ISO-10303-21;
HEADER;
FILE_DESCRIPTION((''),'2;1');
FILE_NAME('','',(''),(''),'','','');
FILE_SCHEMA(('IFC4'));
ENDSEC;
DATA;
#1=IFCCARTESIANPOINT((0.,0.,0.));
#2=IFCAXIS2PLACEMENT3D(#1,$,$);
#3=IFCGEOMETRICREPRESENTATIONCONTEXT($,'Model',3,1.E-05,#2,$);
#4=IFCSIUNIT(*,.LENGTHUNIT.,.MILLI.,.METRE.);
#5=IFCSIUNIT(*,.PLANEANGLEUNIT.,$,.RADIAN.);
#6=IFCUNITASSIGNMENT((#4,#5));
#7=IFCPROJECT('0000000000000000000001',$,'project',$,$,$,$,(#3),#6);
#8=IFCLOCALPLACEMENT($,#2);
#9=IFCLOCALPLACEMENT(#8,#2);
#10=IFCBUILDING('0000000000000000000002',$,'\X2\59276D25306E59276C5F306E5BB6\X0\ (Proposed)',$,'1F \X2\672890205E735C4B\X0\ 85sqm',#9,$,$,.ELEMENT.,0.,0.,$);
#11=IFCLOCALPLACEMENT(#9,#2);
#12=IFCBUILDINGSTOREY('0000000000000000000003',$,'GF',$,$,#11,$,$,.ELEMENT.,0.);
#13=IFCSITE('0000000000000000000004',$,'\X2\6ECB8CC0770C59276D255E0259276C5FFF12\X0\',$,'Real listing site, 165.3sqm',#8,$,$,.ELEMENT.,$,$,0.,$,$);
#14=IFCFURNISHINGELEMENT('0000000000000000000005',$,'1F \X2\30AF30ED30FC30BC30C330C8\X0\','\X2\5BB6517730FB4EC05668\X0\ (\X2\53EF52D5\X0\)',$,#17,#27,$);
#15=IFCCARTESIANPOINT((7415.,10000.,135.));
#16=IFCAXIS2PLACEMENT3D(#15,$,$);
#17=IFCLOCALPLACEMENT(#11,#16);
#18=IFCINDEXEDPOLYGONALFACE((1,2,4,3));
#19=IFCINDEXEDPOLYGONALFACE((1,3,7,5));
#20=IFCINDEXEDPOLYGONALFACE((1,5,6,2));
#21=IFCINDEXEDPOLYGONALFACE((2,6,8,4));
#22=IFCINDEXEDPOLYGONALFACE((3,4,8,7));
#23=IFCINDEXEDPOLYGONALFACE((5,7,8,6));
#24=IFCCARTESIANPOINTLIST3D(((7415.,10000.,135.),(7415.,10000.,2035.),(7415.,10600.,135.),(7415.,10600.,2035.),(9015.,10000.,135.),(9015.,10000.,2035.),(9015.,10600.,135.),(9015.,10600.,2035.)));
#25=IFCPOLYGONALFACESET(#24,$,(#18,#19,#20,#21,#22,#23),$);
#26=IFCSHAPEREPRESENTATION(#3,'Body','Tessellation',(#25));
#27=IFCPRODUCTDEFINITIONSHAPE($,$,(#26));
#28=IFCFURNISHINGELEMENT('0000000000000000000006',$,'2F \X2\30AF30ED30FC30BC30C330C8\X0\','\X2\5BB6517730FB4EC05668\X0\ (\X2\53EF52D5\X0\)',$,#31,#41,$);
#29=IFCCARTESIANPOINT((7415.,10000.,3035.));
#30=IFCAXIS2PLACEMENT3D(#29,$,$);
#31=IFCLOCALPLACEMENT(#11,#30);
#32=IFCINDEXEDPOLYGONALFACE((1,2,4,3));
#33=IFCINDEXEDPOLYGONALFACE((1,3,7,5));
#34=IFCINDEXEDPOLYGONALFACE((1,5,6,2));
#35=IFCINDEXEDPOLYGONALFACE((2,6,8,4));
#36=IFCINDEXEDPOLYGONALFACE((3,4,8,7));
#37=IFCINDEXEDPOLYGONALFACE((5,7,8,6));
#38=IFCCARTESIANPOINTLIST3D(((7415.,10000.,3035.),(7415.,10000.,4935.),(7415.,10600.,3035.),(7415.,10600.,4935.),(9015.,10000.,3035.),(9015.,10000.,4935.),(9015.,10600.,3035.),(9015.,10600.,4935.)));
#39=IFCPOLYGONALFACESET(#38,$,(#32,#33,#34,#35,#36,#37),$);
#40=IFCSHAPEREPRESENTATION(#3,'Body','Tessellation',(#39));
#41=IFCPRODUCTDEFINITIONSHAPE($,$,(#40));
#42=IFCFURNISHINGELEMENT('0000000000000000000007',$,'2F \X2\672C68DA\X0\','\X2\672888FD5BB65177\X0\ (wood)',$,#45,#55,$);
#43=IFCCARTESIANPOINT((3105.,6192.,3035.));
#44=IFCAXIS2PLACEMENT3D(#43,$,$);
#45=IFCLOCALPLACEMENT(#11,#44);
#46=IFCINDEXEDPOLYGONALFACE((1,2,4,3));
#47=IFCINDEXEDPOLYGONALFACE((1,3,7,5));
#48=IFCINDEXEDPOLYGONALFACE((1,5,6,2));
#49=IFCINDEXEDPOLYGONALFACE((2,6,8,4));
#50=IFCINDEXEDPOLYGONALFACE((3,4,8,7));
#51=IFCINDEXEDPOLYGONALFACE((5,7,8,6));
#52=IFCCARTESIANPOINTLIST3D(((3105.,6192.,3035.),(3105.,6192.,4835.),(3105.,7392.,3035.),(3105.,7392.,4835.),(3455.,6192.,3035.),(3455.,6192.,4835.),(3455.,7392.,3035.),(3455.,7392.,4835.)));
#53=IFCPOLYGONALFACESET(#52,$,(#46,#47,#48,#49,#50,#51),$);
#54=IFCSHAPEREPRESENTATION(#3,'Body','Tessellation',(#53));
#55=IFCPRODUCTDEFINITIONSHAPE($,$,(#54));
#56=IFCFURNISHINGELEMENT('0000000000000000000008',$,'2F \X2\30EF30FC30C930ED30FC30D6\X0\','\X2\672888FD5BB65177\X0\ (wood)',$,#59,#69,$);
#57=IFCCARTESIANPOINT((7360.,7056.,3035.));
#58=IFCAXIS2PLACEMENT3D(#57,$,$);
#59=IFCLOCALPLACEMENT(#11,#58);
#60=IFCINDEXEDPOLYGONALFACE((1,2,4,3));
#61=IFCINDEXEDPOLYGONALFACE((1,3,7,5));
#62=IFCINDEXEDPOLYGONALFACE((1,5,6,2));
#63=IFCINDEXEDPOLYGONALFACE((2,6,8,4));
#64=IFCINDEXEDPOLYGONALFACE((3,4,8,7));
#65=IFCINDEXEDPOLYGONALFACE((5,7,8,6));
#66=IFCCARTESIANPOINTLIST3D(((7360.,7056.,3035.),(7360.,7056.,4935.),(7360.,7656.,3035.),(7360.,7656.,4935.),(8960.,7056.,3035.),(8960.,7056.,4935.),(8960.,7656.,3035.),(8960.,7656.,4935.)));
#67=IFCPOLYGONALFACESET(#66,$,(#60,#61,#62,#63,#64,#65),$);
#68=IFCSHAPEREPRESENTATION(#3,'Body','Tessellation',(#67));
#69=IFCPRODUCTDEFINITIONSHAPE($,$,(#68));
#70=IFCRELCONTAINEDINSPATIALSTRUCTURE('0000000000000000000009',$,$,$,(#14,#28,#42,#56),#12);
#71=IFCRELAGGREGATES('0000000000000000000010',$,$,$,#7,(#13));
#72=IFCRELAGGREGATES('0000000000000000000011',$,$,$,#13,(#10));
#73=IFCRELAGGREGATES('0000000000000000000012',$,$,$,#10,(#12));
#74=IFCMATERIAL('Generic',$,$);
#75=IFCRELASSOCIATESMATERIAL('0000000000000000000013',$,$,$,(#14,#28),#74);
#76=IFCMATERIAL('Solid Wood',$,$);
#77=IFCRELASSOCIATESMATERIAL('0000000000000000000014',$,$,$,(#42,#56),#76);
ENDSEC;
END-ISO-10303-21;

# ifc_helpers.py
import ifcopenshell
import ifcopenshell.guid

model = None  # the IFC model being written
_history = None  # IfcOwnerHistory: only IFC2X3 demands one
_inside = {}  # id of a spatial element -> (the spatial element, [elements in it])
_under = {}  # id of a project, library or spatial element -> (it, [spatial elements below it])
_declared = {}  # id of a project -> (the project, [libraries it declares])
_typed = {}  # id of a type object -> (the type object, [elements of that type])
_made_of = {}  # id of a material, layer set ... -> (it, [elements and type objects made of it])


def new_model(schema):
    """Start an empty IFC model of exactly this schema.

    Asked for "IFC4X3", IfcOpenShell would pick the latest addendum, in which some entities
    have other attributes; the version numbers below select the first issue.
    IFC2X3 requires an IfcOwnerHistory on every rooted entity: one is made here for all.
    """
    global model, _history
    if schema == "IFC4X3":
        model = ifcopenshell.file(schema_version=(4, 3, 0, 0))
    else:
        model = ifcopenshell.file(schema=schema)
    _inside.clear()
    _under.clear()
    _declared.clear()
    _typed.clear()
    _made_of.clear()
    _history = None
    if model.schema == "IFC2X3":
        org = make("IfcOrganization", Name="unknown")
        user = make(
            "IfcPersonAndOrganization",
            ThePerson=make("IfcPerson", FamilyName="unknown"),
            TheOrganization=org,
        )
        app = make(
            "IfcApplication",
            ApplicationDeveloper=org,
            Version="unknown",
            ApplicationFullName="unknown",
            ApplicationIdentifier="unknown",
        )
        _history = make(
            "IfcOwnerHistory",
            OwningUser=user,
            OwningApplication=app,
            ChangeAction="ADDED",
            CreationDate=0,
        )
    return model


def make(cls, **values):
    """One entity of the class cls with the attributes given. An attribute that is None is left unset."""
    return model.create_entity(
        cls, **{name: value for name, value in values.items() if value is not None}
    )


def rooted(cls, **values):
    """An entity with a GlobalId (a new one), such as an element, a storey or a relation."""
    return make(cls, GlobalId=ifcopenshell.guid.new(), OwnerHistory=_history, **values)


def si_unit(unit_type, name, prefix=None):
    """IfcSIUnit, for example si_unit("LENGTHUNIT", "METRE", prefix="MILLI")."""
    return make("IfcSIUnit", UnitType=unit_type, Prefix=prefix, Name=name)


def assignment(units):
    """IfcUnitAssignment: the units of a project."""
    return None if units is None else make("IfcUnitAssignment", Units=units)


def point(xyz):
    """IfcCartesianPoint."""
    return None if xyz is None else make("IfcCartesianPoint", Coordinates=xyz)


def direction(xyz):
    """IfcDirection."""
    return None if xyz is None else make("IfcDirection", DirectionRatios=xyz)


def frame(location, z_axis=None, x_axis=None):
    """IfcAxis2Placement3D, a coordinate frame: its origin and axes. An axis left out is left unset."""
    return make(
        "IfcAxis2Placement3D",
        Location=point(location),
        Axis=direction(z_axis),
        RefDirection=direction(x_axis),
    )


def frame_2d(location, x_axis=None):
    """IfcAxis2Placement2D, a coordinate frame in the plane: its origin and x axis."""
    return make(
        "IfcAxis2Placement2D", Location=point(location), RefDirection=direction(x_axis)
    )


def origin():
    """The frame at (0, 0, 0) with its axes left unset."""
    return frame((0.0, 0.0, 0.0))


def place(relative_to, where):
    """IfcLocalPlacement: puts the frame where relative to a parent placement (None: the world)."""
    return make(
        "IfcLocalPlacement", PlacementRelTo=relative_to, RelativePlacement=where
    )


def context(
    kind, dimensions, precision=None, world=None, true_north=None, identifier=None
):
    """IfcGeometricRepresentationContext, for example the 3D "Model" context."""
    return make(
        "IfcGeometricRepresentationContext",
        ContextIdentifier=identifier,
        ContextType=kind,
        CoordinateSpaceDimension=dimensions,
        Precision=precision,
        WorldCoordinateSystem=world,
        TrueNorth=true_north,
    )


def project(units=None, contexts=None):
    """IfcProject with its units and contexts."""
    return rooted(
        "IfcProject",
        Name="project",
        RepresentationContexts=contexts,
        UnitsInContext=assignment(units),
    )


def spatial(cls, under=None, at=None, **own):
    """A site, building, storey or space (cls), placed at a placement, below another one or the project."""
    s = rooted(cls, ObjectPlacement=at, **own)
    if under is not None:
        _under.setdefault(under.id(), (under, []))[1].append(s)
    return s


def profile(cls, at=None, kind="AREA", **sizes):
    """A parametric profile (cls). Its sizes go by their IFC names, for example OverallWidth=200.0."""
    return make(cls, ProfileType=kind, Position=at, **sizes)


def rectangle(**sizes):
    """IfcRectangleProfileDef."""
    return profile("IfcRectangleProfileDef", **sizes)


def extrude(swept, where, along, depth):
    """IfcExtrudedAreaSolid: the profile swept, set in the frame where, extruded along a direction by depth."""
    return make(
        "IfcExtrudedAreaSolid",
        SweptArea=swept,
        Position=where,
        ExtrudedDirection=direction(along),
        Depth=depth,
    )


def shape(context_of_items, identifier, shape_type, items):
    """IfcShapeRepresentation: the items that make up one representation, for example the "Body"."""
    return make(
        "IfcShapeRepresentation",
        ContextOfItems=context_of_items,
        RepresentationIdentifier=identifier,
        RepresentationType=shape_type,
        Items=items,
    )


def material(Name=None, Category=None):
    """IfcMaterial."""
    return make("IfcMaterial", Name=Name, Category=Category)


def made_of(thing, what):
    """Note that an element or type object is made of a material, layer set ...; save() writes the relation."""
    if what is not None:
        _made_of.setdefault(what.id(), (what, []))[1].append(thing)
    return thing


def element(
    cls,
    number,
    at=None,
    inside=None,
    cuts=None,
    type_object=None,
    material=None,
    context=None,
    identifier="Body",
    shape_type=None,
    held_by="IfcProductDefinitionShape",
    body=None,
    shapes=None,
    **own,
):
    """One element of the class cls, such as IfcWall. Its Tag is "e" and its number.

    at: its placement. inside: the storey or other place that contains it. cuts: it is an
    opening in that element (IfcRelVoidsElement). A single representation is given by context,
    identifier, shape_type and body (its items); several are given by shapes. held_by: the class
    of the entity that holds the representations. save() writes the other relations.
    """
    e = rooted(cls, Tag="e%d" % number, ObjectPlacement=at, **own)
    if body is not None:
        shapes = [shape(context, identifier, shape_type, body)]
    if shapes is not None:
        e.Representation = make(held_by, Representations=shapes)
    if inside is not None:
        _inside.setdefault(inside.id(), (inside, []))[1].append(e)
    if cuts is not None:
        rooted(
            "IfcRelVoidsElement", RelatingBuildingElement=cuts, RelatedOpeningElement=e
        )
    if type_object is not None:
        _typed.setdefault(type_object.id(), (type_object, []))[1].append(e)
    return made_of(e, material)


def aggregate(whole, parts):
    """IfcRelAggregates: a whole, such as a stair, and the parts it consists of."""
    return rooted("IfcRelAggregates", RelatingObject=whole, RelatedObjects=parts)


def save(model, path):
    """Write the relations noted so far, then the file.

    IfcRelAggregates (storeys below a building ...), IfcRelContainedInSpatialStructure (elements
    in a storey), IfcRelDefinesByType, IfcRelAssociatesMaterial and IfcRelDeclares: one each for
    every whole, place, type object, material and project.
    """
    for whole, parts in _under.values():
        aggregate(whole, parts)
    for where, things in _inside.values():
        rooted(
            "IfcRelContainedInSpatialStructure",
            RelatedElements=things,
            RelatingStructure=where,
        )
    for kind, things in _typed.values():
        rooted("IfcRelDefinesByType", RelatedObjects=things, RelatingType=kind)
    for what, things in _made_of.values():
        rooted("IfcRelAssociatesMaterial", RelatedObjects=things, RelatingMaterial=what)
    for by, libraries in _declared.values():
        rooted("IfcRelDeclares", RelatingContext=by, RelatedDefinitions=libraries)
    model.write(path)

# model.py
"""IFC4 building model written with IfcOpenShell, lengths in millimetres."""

from ifc_helpers import new_model, si_unit, frame, frame_2d, origin, place, context, project, spatial, rectangle, extrude, material, element, save


model = new_model("IFC4")

# Units and contexts
model_context = context("Model", 3, precision=1e-05, world=origin())
ifc_project = project(units=[si_unit("LENGTHUNIT", "METRE", prefix="MILLI"), si_unit("PLANEANGLEUNIT", "RADIAN")], contexts=[model_context])

# Site, building, storey
site_placement = place(None, origin())
site = spatial("IfcSite", under=ifc_project, at=site_placement, Name="滋賀県大津市大江２", ObjectType="Real listing site, 165.3sqm", CompositionType="ELEMENT", RefElevation=0.0)
building_placement = place(site_placement, origin())
building = spatial("IfcBuilding", under=site, at=building_placement, Name="大津の大江の家 (Proposed)", ObjectType="1F 木造平屋 85sqm", CompositionType="ELEMENT", ElevationOfRefHeight=0.0, ElevationOfTerrain=0.0)
storey_placement = place(building_placement, origin())
storey = spatial("IfcBuildingStorey", under=building, at=storey_placement, Name="GF", CompositionType="ELEMENT", Elevation=0.0)

# Shared definitions
ifc_material_1 = material(Name="Solid Wood")

# Shared definitions
ifc_material_2 = material(Name="Generic")

# Furnishing elements
furnishing_1_placement = place(storey_placement, frame((7415.0, 10000.0, 135.0)))
element("IfcFurnishingElement", 1, at=furnishing_1_placement, inside=storey, material=ifc_material_2, Name="1F クローゼット", Description="家具・什器 (可動)", context=model_context, shape_type="SweptSolid", body=[
    extrude(rectangle(XDim=1600.0, YDim=600.0, at=frame_2d((800.0, 300.0))), frame((7415.0, 10000.0, 135.0)), (0.0, 0.0, 1.0), 1900.0),
])
furnishing_2_placement = place(storey_placement, frame((7415.0, 10000.0, 3035.0)))
element("IfcFurnishingElement", 2, at=furnishing_2_placement, inside=storey, material=ifc_material_2, Name="2F クローゼット", Description="家具・什器 (可動)", context=model_context, shape_type="SweptSolid", body=[
    extrude(rectangle(XDim=1600.0, YDim=600.0, at=frame_2d((800.0, 300.0))), frame((7415.0, 10000.0, 3035.0)), (0.0, 0.0, 1.0), 1900.0),
])
furnishing_3_placement = place(storey_placement, frame((3105.0, 6192.0, 3035.0)))
element("IfcFurnishingElement", 3, at=furnishing_3_placement, inside=storey, material=ifc_material_1, Name="2F 本棚", Description="木製家具 (wood)", context=model_context, shape_type="SweptSolid", body=[
    extrude(rectangle(XDim=350.0, YDim=1200.0, at=frame_2d((175.0, 600.0))), frame((3105.0, 6192.0, 3035.0)), (0.0, 0.0, 1.0), 1800.0),
])
furnishing_4_placement = place(storey_placement, frame((7360.0, 7056.0, 3035.0)))
element("IfcFurnishingElement", 4, at=furnishing_4_placement, inside=storey, material=ifc_material_1, Name="2F ワードローブ", Description="木製家具 (wood)", context=model_context, shape_type="SweptSolid", body=[
    extrude(rectangle(XDim=1600.0, YDim=600.0, at=frame_2d((800.0, 300.0))), frame((7360.0, 7056.0, 3035.0)), (0.0, 0.0, 1.0), 1900.0),
])

save(model, "model.ifc")
